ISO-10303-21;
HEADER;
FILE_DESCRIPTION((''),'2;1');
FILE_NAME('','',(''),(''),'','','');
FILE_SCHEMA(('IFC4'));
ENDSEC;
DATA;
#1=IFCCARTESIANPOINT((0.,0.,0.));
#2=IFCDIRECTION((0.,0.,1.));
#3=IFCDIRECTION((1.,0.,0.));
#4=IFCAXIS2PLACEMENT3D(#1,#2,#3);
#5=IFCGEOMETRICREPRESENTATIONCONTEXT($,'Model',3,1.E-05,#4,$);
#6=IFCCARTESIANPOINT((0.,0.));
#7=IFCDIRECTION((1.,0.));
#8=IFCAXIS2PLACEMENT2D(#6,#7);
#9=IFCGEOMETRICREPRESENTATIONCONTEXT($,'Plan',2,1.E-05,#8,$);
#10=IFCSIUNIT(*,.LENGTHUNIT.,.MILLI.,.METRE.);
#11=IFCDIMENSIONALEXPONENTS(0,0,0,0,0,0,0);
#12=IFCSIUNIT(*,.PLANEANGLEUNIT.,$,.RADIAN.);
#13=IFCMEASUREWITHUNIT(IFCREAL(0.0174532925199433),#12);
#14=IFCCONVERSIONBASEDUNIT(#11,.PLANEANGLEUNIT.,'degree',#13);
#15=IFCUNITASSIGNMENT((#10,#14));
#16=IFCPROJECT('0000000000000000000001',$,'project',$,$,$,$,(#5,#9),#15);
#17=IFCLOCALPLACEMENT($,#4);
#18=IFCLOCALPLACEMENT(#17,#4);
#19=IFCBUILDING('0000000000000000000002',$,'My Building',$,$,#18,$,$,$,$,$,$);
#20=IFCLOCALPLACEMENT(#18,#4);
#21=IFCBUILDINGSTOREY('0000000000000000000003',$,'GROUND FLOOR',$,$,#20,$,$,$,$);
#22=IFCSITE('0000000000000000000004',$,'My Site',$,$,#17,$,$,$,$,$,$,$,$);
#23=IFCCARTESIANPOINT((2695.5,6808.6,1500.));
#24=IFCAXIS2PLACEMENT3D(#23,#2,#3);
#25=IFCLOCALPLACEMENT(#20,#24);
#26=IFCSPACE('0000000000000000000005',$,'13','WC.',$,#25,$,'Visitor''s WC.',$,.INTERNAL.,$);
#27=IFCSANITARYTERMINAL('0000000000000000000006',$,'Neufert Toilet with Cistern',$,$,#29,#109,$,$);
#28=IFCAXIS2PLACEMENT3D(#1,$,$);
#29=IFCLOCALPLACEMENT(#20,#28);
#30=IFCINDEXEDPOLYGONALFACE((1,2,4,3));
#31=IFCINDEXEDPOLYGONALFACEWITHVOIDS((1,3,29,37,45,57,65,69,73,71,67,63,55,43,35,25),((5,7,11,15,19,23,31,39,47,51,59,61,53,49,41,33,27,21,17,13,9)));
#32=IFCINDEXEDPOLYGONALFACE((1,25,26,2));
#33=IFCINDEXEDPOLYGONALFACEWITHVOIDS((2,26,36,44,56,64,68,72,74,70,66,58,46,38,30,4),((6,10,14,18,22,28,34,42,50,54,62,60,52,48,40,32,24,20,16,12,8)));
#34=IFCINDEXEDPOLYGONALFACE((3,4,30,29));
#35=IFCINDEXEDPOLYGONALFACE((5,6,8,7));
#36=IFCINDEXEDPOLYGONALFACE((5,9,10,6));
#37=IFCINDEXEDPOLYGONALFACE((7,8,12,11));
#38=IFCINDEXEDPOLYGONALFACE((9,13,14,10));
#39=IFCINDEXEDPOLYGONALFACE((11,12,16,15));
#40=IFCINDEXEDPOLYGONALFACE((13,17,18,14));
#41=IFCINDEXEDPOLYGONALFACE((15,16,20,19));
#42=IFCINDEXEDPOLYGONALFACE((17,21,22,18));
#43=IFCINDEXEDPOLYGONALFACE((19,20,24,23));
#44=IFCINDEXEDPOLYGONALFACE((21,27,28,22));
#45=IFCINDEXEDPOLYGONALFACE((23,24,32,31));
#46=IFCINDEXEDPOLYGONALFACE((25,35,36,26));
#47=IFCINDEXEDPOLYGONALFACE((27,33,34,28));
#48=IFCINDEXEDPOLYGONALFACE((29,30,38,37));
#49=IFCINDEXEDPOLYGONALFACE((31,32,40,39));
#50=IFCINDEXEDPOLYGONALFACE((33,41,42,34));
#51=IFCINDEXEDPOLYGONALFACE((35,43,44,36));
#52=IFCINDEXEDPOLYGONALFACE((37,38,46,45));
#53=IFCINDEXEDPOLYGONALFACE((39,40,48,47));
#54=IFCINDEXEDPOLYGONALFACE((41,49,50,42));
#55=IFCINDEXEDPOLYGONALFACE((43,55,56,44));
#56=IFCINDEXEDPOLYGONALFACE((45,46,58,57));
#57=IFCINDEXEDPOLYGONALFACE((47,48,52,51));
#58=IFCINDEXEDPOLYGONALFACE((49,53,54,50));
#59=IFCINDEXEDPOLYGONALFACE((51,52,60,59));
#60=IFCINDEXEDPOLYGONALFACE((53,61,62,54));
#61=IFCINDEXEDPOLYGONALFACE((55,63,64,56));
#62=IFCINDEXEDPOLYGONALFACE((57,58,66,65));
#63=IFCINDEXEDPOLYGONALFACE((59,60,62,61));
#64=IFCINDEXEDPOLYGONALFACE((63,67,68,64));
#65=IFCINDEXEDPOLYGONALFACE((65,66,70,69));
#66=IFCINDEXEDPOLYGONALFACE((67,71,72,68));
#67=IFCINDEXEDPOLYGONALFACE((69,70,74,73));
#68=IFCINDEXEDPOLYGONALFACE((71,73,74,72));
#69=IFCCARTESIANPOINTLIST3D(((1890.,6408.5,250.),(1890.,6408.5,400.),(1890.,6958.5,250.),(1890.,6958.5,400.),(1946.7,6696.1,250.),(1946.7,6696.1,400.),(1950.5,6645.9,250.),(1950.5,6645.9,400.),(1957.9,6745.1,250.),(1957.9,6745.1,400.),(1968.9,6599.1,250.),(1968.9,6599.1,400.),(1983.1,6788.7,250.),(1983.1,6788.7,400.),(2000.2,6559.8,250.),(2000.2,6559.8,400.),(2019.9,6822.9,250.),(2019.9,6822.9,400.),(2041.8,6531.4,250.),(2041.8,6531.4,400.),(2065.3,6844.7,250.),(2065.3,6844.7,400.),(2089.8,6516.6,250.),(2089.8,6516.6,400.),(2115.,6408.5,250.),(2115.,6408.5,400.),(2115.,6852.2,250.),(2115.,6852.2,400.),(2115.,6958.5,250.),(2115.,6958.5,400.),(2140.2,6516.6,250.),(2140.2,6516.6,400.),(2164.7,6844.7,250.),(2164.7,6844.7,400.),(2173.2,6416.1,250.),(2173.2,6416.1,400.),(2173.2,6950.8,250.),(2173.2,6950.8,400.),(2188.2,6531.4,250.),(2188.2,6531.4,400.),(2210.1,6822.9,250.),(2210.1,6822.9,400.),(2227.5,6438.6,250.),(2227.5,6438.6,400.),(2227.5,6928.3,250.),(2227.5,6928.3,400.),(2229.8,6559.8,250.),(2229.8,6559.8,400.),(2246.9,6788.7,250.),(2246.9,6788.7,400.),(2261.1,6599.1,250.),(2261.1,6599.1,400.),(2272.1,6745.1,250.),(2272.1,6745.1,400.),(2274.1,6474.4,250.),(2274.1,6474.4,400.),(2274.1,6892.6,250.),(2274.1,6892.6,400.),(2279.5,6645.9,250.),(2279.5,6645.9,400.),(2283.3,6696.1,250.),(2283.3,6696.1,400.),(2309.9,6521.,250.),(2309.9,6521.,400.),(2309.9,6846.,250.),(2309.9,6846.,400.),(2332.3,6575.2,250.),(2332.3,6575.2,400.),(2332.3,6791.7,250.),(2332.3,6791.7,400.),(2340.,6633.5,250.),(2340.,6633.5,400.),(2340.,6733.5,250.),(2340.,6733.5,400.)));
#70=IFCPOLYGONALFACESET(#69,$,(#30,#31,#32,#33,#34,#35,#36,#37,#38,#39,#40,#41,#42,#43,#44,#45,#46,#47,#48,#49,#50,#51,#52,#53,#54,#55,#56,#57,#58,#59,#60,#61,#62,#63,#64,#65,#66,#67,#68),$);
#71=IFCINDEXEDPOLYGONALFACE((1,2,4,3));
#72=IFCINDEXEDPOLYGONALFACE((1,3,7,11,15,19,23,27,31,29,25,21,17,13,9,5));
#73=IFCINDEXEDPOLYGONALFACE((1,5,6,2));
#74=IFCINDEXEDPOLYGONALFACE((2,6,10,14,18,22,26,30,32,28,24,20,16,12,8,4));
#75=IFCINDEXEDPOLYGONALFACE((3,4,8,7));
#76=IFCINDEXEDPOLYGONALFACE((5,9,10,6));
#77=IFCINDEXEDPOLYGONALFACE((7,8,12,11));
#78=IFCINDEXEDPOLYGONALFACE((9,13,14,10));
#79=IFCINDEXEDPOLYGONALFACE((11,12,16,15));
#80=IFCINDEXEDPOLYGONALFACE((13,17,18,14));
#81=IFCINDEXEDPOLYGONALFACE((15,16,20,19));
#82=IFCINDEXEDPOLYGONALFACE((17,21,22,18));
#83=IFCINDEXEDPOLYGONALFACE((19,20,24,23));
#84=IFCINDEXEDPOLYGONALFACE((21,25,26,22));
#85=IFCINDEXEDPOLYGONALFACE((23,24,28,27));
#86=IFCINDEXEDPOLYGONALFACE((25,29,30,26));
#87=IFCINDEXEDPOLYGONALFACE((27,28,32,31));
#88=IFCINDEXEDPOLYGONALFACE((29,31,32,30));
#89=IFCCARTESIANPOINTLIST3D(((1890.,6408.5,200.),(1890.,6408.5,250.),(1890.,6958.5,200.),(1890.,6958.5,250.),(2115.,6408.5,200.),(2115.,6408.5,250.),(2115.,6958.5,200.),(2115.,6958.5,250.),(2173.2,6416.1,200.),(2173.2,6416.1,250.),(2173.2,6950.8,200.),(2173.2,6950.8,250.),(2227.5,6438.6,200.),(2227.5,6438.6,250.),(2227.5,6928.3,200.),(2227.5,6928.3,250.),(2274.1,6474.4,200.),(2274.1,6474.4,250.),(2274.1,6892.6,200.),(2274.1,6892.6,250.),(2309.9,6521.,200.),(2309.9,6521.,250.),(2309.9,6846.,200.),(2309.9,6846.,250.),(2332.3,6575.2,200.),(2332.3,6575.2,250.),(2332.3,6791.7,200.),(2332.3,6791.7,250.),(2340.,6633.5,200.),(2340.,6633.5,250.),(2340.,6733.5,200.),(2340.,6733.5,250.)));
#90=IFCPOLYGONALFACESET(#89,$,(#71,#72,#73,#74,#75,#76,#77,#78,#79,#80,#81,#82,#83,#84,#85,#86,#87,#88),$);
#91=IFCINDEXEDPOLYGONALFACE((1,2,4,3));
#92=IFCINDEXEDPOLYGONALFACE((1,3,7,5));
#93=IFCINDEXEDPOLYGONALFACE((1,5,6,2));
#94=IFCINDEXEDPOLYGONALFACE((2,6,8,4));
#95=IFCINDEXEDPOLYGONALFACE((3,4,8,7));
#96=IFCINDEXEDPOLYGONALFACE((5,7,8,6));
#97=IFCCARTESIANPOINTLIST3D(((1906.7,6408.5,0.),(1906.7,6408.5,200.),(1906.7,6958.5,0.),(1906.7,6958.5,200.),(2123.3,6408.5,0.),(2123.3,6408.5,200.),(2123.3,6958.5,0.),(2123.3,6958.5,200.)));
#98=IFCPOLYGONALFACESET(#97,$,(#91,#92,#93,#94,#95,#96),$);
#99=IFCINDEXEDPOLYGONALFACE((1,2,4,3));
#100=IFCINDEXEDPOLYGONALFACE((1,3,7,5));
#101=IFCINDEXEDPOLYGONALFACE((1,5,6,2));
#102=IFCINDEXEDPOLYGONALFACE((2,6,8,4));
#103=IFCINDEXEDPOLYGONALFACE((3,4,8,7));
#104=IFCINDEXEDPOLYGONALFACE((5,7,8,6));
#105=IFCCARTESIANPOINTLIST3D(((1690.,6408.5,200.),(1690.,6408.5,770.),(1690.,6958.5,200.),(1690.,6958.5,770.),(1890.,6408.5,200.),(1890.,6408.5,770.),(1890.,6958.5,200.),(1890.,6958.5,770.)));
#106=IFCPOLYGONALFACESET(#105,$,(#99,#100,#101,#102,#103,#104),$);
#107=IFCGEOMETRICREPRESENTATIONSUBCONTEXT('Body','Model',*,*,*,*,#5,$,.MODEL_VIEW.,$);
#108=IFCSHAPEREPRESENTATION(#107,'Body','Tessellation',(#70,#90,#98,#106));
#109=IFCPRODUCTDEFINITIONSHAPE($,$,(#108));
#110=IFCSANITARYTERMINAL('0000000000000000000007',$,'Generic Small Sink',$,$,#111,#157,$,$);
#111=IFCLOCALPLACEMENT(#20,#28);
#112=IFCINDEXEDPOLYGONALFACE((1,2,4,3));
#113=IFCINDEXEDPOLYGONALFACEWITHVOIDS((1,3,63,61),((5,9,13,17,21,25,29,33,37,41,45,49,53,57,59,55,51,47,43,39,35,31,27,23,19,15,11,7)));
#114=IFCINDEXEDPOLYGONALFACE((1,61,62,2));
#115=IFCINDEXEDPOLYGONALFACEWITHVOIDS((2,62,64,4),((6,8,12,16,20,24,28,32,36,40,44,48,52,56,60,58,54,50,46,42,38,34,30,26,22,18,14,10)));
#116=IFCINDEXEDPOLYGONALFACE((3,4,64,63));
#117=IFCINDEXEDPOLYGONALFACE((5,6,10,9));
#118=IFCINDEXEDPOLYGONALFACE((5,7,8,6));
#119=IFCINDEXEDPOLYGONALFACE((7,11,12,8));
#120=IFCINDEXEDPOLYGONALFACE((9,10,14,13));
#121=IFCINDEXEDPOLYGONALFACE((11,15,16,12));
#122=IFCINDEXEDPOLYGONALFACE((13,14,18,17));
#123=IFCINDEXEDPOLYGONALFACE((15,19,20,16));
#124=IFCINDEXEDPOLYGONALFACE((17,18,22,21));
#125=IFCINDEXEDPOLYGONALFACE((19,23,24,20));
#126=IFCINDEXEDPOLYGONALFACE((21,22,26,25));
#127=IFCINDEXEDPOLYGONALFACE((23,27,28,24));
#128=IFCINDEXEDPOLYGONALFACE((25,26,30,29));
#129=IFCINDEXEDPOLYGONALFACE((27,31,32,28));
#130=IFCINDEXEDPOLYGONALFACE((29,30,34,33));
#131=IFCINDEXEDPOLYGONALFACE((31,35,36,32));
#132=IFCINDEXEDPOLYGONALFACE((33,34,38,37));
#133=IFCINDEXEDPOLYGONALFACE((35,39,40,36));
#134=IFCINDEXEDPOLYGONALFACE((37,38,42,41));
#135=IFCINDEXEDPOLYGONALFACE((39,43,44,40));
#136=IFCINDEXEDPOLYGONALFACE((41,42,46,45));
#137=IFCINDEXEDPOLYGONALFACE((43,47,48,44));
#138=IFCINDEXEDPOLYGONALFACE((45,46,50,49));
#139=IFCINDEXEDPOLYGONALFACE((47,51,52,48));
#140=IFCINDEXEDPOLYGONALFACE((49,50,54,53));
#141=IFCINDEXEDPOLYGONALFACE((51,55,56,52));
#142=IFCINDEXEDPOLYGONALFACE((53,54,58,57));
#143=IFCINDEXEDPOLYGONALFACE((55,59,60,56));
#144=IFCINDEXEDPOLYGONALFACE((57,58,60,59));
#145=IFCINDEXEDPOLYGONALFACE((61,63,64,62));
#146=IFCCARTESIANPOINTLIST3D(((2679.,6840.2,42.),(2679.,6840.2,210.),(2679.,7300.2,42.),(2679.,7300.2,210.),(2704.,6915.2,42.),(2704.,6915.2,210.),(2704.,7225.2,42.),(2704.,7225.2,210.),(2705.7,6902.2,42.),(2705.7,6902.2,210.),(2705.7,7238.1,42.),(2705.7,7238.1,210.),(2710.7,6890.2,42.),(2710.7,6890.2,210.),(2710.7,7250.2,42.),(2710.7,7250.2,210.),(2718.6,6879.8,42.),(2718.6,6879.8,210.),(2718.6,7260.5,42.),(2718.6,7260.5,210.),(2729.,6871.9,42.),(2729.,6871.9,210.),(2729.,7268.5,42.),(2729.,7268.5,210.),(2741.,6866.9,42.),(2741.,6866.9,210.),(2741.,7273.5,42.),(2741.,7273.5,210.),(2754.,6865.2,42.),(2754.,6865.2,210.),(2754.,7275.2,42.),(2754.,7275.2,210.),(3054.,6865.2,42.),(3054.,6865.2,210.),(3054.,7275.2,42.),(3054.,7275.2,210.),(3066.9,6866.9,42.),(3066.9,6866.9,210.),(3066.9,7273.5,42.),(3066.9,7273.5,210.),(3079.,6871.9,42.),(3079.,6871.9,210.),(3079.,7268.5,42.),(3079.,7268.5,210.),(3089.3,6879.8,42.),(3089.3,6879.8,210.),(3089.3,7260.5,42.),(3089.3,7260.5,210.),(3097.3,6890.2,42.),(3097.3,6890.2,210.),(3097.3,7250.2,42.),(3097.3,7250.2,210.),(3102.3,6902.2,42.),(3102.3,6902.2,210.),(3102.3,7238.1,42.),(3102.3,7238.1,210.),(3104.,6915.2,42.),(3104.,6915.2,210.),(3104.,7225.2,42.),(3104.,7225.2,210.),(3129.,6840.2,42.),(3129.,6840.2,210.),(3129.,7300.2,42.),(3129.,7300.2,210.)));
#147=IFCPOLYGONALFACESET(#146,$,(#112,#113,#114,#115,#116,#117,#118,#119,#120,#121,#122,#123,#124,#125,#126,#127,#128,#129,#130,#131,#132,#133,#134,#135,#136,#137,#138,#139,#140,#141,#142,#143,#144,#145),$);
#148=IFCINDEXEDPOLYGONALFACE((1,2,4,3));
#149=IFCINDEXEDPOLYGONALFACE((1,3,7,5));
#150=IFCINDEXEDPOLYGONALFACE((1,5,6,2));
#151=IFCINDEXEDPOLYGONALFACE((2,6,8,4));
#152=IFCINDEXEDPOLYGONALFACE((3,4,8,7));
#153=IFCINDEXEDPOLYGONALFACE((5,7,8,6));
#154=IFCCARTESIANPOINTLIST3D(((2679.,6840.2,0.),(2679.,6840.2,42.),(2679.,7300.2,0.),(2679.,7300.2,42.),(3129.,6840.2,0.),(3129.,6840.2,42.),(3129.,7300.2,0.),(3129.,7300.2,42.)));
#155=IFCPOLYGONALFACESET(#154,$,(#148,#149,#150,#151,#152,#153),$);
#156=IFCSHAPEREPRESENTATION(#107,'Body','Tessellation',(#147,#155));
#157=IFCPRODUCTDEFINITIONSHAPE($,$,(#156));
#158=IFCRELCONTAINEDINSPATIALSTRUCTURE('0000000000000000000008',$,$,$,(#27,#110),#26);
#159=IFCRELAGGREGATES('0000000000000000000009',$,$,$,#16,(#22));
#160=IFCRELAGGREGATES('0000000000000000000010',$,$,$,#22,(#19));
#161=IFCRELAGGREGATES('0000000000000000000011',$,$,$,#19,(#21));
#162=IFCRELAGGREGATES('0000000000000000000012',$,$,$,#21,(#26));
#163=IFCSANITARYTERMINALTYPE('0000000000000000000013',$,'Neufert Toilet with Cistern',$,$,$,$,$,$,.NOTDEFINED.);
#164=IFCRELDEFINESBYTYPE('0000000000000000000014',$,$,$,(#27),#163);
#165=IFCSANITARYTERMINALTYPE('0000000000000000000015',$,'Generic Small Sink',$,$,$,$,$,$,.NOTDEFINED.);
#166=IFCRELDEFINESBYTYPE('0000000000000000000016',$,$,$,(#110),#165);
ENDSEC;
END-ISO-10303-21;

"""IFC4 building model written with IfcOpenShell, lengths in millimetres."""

from ifc_helpers import new_model, entity, si_unit, converted_unit, frame, frame_2d, origin_with_axes, origin_2d_with_axis, place, context, subcontext, project, spatial, line, arc, indexed_curve, circle_curve, outline, extrude, shape, source, transform, mapped, type_object, type_shapes, element, save


model = new_model("IFC4")

# Units and contexts
model_context = context("Model", 3, precision=1e-05, world=origin_with_axes())
plan_context = context("Plan", 2, precision=1e-05, world=origin_2d_with_axis())
body_context_1 = subcontext(model_context, "Body", "Model", "MODEL_VIEW")
body_context_2 = subcontext(plan_context, "Body", "Plan", "PLAN_VIEW")
ifc_project = project(units=[si_unit("LENGTHUNIT", "METRE", prefix="MILLI"), converted_unit("PLANEANGLEUNIT", "degree", entity("IfcReal", 0.0174532925199433), si_unit("PLANEANGLEUNIT", "RADIAN"), dimensions=[0, 0, 0, 0, 0, 0, 0])], contexts=[model_context, plan_context])

# Site, building, storey
site_placement = place(None, origin_with_axes())
site = spatial("IfcSite", under=ifc_project, at=site_placement, Name="My Site")
building_placement = place(site_placement, origin_with_axes())
building = spatial("IfcBuilding", under=site, at=building_placement, Name="My Building")
storey_placement = place(building_placement, origin_with_axes())
storey = spatial("IfcBuildingStorey", under=building, at=storey_placement, Name="GROUND FLOOR")

# Shared definitions
space_1_placement = place(storey_placement, frame((2695.5, 6808.6, 1500.0), z_axis=(0.0, 0.0, 1.0), x_axis=(1.0, 0.0, 0.0)))
space_1 = spatial("IfcSpace", under=storey, at=space_1_placement, Name="13", Description="WC.", LongName="Visitor's WC.", PredefinedType="INTERNAL")

# Sanitary terminals
sanitary_terminal_type_1 = type_object("IfcSanitaryTerminalType", Name="Neufert Toilet with Cistern", PredefinedType="NOTDEFINED")
shared_shape_1 = source(origin_with_axes(), body_context_1, "Body", "SweptSolid", [
    extrude(outline(indexed_curve([(-275.0, -200.0), (275.0, -200.0), (275.0, -425.0), (209.1, -584.1), (50.0, -650.0), (-50.0, -650.0), (-209.1, -584.1), (-275.0, -425.0)], segments=[line(1, 2), line(2, 3), arc(3, 4, 5), line(5, 6), arc(6, 7, 8), line(8, 1)]), holes=[circle_curve(frame_2d((0.0, -425.0)), 168.8)]), frame((0.0, 0.0, 250.0), z_axis=(0.0, 0.0, 1.0), x_axis=(1.0, 0.0, 0.0)), (0.0, 0.0, 1.0), 150.0),
    extrude(outline(indexed_curve([(-275.0, -200.0), (275.0, -200.0), (275.0, -425.0), (209.1, -584.1), (50.0, -650.0), (-50.0, -650.0), (-209.1, -584.1), (-275.0, -425.0)], segments=[line(1, 2), line(2, 3), arc(3, 4, 5), line(5, 6), arc(6, 7, 8), line(8, 1)])), frame((0.0, 0.0, 200.0), z_axis=(0.0, 0.0, 1.0), x_axis=(1.0, 0.0, 0.0)), (0.0, 0.0, 1.0), 50.0),
    extrude(outline(indexed_curve([(-275.0, -216.7), (275.0, -216.7), (275.0, -433.3), (-275.0, -433.3)], segments=[line(1, 2, 3, 4, 1)])), origin_with_axes(), (0.0, 0.0, 1.0), 200.0),
    extrude(outline(indexed_curve([(-275.0, 0.0), (275.0, 0.0), (275.0, -200.0), (-275.0, -200.0)], segments=[line(1, 2, 3, 4, 1)])), frame((0.0, 0.0, 200.0), z_axis=(0.0, 0.0, 1.0), x_axis=(1.0, 0.0, 0.0)), (0.0, 0.0, 1.0), 570.0),
])
shared_shape_2 = source(origin_with_axes(), body_context_2, "Body", "Curve2D", [
    entity("IfcIndexedPolyCurve", entity("IfcCartesianPointList2D", [[-275.0, 0.0], [275.0, 0.0], [275.0, -200.0], [-275.0, -200.0]]), [entity("IfcLineIndex", [1, 2, 3, 4, 1])]),
    entity("IfcIndexedPolyCurve", entity("IfcCartesianPointList2D", [[165.0, -200.0], [192.5, -335.0]])),
    entity("IfcTrimmedCurve", entity("IfcEllipse", entity("IfcAxis2Placement2D", entity("IfcCartesianPoint", [0.0, -335.0]), entity("IfcDirection", [1.0, 0.0])), 192.5, 315.0), [entity("IfcCartesianPoint", [-192.5, -335.0])], [entity("IfcCartesianPoint", [192.5, -335.0])], True, "CARTESIAN"),
    entity("IfcIndexedPolyCurve", entity("IfcCartesianPointList2D", [[-165.0, -200.0], [-192.5, -335.0]])),
    entity("IfcEllipse", entity("IfcAxis2Placement2D", entity("IfcCartesianPoint", [0.0, -452.0]), entity("IfcDirection", [1.0, 0.0])), 131.2, 157.5),
    entity("IfcIndexedPolyCurve", entity("IfcCartesianPointList2D", [[-34.4, -452.0], [-34.4, -429.5], [34.4, -429.5], [34.4, -452.0]])),
    entity("IfcTrimmedCurve", entity("IfcEllipse", entity("IfcAxis2Placement2D", entity("IfcCartesianPoint", [0.0, -452.0]), entity("IfcDirection", [1.0, 0.0])), 34.4, 22.5), [entity("IfcCartesianPoint", [-34.4, -452.0])], [entity("IfcCartesianPoint", [34.4, -452.0])], True, "CARTESIAN"),
])
type_shapes(sanitary_terminal_type_1, [shared_shape_1, shared_shape_2])
sanitary_terminal_1_placement = place(space_1_placement, frame((-1005.5, -125.1, -1500.0), z_axis=(0.0, 0.0, 1.0), x_axis=(0.0, 1.0, 0.0)))
element("IfcSanitaryTerminal", 1, at=sanitary_terminal_1_placement, inside=space_1, type_object=sanitary_terminal_type_1, Name="Neufert Toilet with Cistern", shapes=[
    shape(body_context_1, "Body", "MappedRepresentation", [mapped(shared_shape_1, transform((0.0, 0.0, 0.0), x_axis=(1.0, 0.0, 0.0), y_axis=(0.0, 1.0, 0.0), z_axis=(0.0, 0.0, 1.0), scale=1.0))]),
    shape(body_context_2, "Body", "MappedRepresentation", [mapped(shared_shape_2, transform((0.0, 0.0, 0.0), x_axis=(1.0, 0.0, 0.0), y_axis=(0.0, 1.0, 0.0), z_axis=(0.0, 0.0, 1.0), scale=1.0))]),
])
sanitary_terminal_type_2 = type_object("IfcSanitaryTerminalType", Name="Generic Small Sink", PredefinedType="NOTDEFINED")
shared_indexed_poly_curve = entity("IfcIndexedPolyCurve", entity("IfcCartesianPointList2D", [[0.0, 0.0], [450.0, 0.0], [450.0, 460.0], [0.0, 460.0]]), [entity("IfcLineIndex", [1, 2, 3, 4, 1])])
shared_shape_3 = source(origin_with_axes(), body_context_1, "Body", "SweptSolid", [
    entity("IfcExtrudedAreaSolid", entity("IfcArbitraryProfileDefWithVoids", "AREA", None, shared_indexed_poly_curve, [entity("IfcIndexedPolyCurve", entity("IfcCartesianPointList2D", [[25.0, 75.0], [39.6, 39.6], [75.0, 25.0], [375.0, 25.0], [410.4, 39.6], [425.0, 75.0], [425.0, 385.0], [410.4, 420.4], [375.0, 435.0], [75.0, 435.0], [39.6, 420.4], [25.0, 385.0]]), [entity("IfcLineIndex", [12, 1]), entity("IfcArcIndex", [1, 2, 3]), entity("IfcLineIndex", [3, 4]), entity("IfcArcIndex", [4, 5, 6]), entity("IfcLineIndex", [6, 7]), entity("IfcArcIndex", [7, 8, 9]), entity("IfcLineIndex", [9, 10]), entity("IfcArcIndex", [10, 11, 12]), entity("IfcLineIndex", [12, 1])])]), entity("IfcAxis2Placement3D", entity("IfcCartesianPoint", [-225.0, -460.0, 42.0]), entity("IfcDirection", [0.0, 0.0, 1.0]), entity("IfcDirection", [1.0, 0.0, 0.0])), entity("IfcDirection", [0.0, 0.0, 1.0]), 168.0),
    entity("IfcExtrudedAreaSolid", entity("IfcArbitraryClosedProfileDef", "AREA", None, shared_indexed_poly_curve), entity("IfcAxis2Placement3D", entity("IfcCartesianPoint", [-225.0, -460.0, 0.0]), entity("IfcDirection", [0.0, 0.0, 1.0]), entity("IfcDirection", [1.0, 0.0, 0.0])), entity("IfcDirection", [0.0, 0.0, 1.0]), 42.0),
])
shared_shape_4 = source(origin_with_axes(), body_context_2, "Body", "Curve2D", [
    entity("IfcIndexedPolyCurve", entity("IfcCartesianPointList2D", [[-225.0, -460.0], [225.0, -460.0], [225.0, 0.0], [-225.0, 0.0]]), [entity("IfcLineIndex", [1, 2, 3, 4, 1])]),
    entity("IfcIndexedPolyCurve", entity("IfcCartesianPointList2D", [[-200.0, -385.0], [-185.4, -420.4], [-150.0, -435.0], [150.0, -435.0], [185.4, -420.4], [200.0, -385.0], [200.0, -75.0], [185.4, -39.6], [150.0, -25.0], [-150.0, -25.0], [-185.4, -39.6], [-200.0, -75.0]]), [entity("IfcLineIndex", [12, 1]), entity("IfcArcIndex", [1, 2, 3]), entity("IfcLineIndex", [3, 4]), entity("IfcArcIndex", [4, 5, 6]), entity("IfcLineIndex", [6, 7]), entity("IfcArcIndex", [7, 8, 9]), entity("IfcLineIndex", [9, 10]), entity("IfcArcIndex", [10, 11, 12]), entity("IfcLineIndex", [12, 1])]),
    entity("IfcCircle", entity("IfcAxis2Placement2D", entity("IfcCartesianPoint", [0.0, -125.0])), 25.0),
    entity("IfcIndexedPolyCurve", entity("IfcCartesianPointList2D", [[0.0, -12.5], [0.0, -132.5]])),
])
type_shapes(sanitary_terminal_type_2, [shared_shape_3, shared_shape_4])
sanitary_terminal_2_placement = place(space_1_placement, frame((208.5, 491.6, -1500.0), z_axis=(0.0, 0.0, 1.0), x_axis=(1.0, 0.000001, 0.0)))
element("IfcSanitaryTerminal", 2, at=sanitary_terminal_2_placement, inside=space_1, type_object=sanitary_terminal_type_2, Name="Generic Small Sink", shapes=[
    shape(body_context_1, "Body", "MappedRepresentation", [mapped(shared_shape_3, transform((0.0, 0.0, 0.0), x_axis=(1.0, 0.0, 0.0), y_axis=(0.0, 1.0, 0.0), z_axis=(0.0, 0.0, 1.0), scale=1.0))]),
    shape(body_context_2, "Body", "MappedRepresentation", [mapped(shared_shape_4, transform((0.0, 0.0, 0.0), x_axis=(1.0, 0.0, 0.0), y_axis=(0.0, 1.0, 0.0), z_axis=(0.0, 0.0, 1.0), scale=1.0))]),
])

save(model, "model.ifc")
